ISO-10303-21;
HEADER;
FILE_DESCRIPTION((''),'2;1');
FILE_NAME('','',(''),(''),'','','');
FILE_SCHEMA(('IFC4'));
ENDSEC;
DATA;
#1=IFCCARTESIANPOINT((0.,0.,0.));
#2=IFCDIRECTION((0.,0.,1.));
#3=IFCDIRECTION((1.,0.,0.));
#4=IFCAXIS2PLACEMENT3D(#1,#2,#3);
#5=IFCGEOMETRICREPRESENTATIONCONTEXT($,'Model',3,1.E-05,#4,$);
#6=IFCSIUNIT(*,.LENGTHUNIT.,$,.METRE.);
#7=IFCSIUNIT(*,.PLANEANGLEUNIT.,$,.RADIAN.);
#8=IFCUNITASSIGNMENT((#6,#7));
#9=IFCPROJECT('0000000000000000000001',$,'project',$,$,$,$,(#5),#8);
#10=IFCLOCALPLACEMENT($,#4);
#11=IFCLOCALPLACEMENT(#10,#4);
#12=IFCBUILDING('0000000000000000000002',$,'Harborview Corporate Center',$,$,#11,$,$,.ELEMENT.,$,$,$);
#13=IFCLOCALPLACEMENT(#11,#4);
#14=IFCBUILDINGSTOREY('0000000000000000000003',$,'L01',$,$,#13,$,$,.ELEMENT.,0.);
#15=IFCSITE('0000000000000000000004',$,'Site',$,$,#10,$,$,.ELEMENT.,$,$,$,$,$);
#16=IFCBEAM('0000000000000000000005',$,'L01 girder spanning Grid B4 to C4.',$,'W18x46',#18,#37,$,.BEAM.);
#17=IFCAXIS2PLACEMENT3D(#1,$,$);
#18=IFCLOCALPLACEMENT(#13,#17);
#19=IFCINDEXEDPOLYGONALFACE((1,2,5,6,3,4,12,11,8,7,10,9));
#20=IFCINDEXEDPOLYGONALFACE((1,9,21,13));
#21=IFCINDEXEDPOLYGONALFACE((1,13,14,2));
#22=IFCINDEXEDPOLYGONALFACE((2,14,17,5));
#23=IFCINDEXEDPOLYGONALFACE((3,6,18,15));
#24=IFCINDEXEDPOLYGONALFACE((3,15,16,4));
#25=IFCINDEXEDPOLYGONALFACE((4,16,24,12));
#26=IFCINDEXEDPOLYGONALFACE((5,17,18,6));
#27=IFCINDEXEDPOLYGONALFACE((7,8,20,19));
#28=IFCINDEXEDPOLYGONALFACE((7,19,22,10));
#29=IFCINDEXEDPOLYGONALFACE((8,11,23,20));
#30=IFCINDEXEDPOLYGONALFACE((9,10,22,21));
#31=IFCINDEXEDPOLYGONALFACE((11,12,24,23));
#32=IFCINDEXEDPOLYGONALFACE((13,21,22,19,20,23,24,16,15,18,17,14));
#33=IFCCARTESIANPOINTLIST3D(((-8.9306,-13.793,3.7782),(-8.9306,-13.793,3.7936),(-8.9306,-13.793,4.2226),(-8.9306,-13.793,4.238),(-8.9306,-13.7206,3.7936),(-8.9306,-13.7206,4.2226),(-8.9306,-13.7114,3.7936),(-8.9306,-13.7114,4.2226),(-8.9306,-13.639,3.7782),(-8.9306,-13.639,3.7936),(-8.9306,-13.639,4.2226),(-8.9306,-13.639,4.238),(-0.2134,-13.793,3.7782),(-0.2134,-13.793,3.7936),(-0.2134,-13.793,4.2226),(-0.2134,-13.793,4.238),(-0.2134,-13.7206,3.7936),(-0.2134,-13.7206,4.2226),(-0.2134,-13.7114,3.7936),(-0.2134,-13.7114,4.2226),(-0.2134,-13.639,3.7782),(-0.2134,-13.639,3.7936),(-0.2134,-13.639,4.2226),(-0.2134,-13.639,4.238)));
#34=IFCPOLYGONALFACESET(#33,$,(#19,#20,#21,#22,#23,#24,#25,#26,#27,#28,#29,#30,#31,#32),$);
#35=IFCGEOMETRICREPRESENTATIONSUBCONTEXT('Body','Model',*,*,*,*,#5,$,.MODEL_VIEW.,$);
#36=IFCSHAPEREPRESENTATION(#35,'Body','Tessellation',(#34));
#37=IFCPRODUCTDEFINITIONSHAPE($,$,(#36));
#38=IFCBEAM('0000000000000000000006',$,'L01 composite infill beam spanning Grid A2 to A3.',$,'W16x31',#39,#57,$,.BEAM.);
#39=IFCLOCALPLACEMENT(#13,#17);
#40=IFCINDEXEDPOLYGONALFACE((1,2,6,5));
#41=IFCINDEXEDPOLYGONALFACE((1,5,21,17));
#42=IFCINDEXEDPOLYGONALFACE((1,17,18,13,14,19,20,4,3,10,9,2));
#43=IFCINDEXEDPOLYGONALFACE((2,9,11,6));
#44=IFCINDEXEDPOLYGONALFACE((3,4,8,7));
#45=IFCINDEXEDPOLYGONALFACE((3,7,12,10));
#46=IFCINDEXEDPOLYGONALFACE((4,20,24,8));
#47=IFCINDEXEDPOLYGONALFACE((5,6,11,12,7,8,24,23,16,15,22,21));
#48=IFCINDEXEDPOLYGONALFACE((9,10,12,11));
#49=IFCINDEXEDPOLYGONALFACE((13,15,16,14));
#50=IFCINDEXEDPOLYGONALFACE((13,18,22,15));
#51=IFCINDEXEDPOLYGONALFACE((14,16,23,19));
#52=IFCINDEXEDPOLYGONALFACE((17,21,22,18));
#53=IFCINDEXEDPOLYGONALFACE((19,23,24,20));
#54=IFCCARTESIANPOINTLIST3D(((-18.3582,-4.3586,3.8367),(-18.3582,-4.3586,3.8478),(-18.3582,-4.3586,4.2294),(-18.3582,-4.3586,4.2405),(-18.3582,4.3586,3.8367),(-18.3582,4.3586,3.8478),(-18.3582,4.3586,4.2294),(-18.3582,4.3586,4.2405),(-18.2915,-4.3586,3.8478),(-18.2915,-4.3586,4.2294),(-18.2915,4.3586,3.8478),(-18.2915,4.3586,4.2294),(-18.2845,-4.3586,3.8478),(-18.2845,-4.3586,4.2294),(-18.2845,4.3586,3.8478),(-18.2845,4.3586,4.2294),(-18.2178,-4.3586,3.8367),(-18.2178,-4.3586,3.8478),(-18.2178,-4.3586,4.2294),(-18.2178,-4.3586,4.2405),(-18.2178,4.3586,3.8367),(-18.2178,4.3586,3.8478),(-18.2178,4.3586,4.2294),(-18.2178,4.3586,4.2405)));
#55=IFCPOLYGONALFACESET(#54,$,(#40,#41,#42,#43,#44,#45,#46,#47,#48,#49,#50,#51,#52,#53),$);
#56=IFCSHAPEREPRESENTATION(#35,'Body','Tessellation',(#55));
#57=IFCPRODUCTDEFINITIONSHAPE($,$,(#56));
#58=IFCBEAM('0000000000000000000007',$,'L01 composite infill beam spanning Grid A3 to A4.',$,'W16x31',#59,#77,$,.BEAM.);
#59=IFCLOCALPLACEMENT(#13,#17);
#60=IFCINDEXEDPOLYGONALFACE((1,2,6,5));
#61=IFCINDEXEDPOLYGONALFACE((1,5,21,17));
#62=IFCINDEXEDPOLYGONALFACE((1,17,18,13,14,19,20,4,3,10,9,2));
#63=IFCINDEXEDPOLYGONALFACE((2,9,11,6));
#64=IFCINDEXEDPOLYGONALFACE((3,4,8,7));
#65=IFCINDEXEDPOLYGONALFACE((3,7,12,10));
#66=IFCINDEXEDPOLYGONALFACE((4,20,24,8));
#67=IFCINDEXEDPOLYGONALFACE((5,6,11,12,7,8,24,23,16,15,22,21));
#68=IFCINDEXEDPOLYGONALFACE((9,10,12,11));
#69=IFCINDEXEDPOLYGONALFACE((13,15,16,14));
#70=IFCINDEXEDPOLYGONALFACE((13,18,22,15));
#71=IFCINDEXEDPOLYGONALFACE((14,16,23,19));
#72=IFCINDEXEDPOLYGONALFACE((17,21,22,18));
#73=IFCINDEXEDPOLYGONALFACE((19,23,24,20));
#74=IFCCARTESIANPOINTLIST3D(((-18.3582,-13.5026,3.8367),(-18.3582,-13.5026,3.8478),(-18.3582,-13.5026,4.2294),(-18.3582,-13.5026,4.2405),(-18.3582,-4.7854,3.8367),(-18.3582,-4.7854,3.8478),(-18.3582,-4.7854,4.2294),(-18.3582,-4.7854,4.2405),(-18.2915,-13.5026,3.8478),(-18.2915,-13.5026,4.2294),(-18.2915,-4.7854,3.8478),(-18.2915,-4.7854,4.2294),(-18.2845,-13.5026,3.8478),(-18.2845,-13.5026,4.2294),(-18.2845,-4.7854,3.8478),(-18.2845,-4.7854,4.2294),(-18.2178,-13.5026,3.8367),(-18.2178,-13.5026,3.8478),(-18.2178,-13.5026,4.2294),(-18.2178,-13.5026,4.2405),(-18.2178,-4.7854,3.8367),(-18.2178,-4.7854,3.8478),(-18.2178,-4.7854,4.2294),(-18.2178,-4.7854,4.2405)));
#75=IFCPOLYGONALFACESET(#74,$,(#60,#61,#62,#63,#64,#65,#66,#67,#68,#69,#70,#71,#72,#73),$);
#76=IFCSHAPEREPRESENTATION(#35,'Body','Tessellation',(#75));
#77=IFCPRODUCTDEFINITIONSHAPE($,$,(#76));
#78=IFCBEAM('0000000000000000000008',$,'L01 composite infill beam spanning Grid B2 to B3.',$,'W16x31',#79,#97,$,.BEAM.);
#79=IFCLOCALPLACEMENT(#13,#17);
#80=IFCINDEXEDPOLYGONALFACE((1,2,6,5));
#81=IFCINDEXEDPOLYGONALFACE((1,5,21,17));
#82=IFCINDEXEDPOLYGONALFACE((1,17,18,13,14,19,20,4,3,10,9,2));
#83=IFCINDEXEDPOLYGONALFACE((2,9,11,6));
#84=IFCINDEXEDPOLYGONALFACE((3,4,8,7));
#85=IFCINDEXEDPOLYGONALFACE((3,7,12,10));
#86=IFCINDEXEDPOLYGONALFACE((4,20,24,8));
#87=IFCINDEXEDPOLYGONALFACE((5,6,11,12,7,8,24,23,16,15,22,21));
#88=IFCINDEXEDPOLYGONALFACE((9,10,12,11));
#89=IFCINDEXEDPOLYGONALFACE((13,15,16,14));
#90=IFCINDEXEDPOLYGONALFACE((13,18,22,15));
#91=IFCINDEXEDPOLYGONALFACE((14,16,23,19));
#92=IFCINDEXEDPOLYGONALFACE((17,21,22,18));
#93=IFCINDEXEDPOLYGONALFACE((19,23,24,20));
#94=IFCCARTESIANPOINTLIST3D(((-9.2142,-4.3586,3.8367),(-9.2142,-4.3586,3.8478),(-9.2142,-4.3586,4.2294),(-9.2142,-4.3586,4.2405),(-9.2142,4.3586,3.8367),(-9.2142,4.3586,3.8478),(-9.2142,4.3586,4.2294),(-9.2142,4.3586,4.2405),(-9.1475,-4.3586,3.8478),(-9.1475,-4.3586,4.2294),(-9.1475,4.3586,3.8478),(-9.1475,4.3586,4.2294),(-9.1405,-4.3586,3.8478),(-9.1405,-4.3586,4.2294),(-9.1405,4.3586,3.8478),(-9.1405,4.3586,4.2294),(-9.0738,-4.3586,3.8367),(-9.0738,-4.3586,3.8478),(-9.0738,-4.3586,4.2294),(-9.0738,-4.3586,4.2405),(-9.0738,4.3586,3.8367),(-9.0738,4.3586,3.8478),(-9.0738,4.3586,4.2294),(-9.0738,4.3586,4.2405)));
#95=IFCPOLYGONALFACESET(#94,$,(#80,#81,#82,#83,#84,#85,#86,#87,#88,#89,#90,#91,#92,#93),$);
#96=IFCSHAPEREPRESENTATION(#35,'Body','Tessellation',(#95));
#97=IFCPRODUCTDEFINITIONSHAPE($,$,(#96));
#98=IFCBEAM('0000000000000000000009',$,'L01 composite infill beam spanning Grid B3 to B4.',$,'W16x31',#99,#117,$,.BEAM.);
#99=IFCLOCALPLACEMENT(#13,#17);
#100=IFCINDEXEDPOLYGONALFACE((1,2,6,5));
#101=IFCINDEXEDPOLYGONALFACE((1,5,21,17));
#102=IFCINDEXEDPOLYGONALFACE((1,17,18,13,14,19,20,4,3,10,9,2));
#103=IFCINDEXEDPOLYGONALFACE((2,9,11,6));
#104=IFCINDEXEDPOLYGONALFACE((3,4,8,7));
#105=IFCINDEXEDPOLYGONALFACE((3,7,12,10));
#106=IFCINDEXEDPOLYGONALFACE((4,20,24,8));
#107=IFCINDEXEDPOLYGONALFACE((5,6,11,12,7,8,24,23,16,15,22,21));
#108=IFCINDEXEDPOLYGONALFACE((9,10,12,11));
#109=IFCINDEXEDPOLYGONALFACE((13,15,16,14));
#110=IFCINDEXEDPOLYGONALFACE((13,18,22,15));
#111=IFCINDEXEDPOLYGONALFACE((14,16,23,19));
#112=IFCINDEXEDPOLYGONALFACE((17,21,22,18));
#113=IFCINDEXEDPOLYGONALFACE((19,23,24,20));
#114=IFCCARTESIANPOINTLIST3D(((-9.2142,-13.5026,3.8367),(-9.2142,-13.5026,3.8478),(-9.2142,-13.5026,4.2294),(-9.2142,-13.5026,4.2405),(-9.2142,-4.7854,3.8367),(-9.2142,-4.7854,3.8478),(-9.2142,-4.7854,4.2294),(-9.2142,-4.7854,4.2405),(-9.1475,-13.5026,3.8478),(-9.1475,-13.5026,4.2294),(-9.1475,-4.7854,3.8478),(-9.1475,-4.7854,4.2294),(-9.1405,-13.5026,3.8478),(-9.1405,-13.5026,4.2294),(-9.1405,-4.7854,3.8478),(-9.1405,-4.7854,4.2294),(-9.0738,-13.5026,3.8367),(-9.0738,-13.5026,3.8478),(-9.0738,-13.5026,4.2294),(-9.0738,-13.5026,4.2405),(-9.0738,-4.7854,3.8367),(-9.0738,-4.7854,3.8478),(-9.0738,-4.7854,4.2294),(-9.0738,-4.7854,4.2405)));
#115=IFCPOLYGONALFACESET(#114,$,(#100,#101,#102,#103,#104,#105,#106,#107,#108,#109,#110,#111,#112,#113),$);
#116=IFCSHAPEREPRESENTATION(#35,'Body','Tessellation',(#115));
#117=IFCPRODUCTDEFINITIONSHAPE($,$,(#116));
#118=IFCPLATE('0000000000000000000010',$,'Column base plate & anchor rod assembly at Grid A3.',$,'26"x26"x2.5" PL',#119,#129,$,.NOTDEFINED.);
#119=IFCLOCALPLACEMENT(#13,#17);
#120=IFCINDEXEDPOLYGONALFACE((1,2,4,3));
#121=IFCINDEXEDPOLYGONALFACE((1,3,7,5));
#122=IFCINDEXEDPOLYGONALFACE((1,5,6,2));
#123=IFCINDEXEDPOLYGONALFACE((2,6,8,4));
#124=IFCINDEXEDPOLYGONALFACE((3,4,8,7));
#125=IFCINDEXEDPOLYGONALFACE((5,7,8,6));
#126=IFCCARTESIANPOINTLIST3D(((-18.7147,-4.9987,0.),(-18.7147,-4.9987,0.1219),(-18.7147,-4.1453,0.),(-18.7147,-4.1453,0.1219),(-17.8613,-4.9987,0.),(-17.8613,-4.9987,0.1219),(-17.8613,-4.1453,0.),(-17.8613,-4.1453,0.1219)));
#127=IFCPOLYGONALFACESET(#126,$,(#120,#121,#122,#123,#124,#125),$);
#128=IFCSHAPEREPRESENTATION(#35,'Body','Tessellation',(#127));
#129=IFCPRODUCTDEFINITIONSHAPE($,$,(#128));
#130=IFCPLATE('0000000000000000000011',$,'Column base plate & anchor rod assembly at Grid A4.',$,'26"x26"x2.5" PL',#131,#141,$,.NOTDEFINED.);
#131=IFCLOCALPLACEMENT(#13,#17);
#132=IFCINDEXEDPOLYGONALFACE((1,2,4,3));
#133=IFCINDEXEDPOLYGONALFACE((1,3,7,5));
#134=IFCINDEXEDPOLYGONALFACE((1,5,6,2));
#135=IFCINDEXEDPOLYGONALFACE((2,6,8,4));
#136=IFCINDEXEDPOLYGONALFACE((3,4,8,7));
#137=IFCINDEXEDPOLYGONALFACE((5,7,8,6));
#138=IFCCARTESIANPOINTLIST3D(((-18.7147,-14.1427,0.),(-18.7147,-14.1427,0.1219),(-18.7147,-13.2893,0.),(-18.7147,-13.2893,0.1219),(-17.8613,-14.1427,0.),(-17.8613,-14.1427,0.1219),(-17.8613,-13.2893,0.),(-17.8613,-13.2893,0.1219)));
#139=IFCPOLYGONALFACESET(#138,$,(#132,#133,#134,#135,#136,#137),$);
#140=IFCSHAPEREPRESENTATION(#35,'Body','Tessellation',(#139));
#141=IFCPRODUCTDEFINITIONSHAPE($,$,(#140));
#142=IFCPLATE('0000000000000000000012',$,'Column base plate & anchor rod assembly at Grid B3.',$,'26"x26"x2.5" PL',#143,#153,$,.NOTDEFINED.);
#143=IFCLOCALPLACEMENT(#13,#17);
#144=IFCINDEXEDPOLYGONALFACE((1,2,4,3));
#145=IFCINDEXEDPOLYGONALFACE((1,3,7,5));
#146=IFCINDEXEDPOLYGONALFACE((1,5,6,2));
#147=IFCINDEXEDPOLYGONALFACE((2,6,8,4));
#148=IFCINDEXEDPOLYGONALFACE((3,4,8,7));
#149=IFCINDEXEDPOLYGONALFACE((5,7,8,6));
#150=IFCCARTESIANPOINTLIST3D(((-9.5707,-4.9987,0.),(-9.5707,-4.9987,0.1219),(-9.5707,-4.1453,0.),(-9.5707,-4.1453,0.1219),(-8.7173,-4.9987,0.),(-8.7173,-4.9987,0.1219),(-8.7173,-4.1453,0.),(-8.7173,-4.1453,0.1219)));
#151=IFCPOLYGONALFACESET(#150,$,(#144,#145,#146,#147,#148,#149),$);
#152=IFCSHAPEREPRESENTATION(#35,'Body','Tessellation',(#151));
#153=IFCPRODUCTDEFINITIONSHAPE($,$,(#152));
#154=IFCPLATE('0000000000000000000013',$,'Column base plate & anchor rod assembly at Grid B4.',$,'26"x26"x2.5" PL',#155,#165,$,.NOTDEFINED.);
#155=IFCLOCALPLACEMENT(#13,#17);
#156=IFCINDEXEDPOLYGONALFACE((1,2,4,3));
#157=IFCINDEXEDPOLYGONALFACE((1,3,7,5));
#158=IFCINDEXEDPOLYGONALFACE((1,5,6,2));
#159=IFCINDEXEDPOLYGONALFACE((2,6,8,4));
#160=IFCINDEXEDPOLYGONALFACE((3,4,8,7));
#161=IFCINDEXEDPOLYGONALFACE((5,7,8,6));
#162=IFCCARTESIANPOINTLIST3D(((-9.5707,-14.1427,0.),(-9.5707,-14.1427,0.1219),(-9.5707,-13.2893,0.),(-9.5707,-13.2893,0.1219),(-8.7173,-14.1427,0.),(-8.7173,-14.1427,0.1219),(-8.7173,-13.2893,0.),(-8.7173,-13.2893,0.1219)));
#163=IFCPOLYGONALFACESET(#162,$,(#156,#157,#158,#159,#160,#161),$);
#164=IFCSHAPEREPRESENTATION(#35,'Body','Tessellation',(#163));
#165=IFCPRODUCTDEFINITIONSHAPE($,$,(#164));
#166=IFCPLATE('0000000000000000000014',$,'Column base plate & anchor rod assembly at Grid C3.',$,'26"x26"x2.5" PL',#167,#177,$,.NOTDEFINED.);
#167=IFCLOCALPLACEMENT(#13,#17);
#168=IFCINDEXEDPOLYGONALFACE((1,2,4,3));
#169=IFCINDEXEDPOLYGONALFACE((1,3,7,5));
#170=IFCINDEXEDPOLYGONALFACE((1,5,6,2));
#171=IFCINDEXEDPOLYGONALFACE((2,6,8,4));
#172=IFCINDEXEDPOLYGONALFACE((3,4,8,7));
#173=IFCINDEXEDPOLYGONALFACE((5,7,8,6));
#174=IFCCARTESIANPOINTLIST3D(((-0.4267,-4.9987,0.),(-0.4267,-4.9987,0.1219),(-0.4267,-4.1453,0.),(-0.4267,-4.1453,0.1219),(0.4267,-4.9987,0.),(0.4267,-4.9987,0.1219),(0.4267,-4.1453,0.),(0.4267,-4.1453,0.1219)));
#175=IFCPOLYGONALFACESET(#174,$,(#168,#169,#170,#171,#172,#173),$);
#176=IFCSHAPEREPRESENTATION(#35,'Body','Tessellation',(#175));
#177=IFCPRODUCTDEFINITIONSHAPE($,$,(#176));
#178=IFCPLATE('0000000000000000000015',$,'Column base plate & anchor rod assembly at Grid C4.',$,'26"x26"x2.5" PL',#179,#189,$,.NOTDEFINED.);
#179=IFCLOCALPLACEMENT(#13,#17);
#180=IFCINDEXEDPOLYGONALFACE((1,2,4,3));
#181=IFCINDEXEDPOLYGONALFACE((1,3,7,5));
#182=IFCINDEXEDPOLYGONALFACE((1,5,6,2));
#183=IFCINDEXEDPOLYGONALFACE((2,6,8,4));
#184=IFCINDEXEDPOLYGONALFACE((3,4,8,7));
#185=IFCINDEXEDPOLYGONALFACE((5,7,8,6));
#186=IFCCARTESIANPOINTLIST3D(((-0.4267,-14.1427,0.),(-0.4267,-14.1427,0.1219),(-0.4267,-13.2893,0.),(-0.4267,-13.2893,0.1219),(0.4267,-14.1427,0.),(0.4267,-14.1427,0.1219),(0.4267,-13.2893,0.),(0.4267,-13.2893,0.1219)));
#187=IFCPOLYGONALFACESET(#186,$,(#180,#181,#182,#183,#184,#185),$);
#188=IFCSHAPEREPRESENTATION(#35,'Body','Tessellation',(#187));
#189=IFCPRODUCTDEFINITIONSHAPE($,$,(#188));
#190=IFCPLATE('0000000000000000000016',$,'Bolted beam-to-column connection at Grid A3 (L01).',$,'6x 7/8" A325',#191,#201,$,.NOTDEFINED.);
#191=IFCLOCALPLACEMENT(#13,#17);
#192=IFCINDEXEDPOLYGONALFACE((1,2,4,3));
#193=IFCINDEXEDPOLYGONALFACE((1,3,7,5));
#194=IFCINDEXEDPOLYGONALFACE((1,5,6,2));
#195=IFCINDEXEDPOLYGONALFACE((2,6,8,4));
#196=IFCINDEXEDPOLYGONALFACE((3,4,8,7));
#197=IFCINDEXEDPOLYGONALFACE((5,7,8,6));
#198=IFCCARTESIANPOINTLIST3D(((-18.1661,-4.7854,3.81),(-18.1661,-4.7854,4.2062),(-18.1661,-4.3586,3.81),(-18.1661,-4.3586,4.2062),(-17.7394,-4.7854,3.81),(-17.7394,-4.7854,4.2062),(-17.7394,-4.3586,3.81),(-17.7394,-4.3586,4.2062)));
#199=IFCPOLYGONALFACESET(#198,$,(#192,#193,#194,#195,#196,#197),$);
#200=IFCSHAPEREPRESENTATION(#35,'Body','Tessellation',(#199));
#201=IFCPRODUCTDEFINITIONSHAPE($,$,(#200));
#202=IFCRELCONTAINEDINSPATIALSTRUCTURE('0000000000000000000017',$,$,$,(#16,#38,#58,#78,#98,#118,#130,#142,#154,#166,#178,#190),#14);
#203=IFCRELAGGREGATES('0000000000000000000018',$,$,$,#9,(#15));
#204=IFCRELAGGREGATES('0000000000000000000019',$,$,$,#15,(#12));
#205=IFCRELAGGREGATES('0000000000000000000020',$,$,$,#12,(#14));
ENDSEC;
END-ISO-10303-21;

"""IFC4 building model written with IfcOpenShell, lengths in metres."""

from ifc_helpers import new_model, si_unit, frame, origin_with_axes, place, context, subcontext, project, spatial, rectangle, i_section, extrude, element, save


model = new_model("IFC4")

# Units and contexts
model_context = context("Model", 3, precision=1e-05, world=origin_with_axes())
body_context = subcontext(model_context, "Body", "Model", "MODEL_VIEW")
ifc_project = project(units=[si_unit("LENGTHUNIT", "METRE"), si_unit("PLANEANGLEUNIT", "RADIAN")], contexts=[model_context])

# Site, building, storey
site_placement = place(None, origin_with_axes())
site = spatial("IfcSite", under=ifc_project, at=site_placement, Name="Site", CompositionType="ELEMENT")
building_placement = place(site_placement, origin_with_axes())
building = spatial("IfcBuilding", under=site, at=building_placement, Name="Harborview Corporate Center", CompositionType="ELEMENT")
storey_placement = place(building_placement, origin_with_axes())
storey = spatial("IfcBuildingStorey", under=building, at=storey_placement, Name="L01", CompositionType="ELEMENT", Elevation=0.0)

# Beams
beam_1_placement = place(storey_placement, frame((-8.9306, -13.716, 4.0081), z_axis=(1.0, 0.0, 0.0), x_axis=(0.0, 1.0, 0.0)))
element("IfcBeam", 1, at=beam_1_placement, inside=storey, Name="L01 girder spanning Grid B4 to C4.", ObjectType="W18x46", PredefinedType="BEAM", context=body_context, shape_type="SweptSolid", body=[
    extrude(i_section(OverallWidth=0.1539, OverallDepth=0.4597, WebThickness=0.0091, FlangeThickness=0.0154), origin_with_axes(), (0.0, 0.0, 1.0), 8.7173),
])
beam_2_placement = place(storey_placement, frame((-18.288, -4.3586, 4.0386), z_axis=(0.0, 1.0, 0.0), x_axis=(-1.0, 0.0, 0.0)))
element("IfcBeam", 2, at=beam_2_placement, inside=storey, Name="L01 composite infill beam spanning Grid A2 to A3.", ObjectType="W16x31", PredefinedType="BEAM", context=body_context, shape_type="SweptSolid", body=[
    extrude(i_section(OverallWidth=0.1405, OverallDepth=0.4039, WebThickness=0.007, FlangeThickness=0.0112), origin_with_axes(), (0.0, 0.0, 1.0), 8.7173),
])
beam_3_placement = place(storey_placement, frame((-18.288, -13.5026, 4.0386), z_axis=(0.0, 1.0, 0.0), x_axis=(-1.0, 0.0, 0.0)))
element("IfcBeam", 3, at=beam_3_placement, inside=storey, Name="L01 composite infill beam spanning Grid A3 to A4.", ObjectType="W16x31", PredefinedType="BEAM", context=body_context, shape_type="SweptSolid", body=[
    extrude(i_section(OverallWidth=0.1405, OverallDepth=0.4039, WebThickness=0.007, FlangeThickness=0.0112), origin_with_axes(), (0.0, 0.0, 1.0), 8.7173),
])
beam_4_placement = place(storey_placement, frame((-9.144, -4.3586, 4.0386), z_axis=(0.0, 1.0, 0.0), x_axis=(-1.0, 0.0, 0.0)))
element("IfcBeam", 4, at=beam_4_placement, inside=storey, Name="L01 composite infill beam spanning Grid B2 to B3.", ObjectType="W16x31", PredefinedType="BEAM", context=body_context, shape_type="SweptSolid", body=[
    extrude(i_section(OverallWidth=0.1405, OverallDepth=0.4039, WebThickness=0.007, FlangeThickness=0.0112), origin_with_axes(), (0.0, 0.0, 1.0), 8.7173),
])
beam_5_placement = place(storey_placement, frame((-9.144, -13.5026, 4.0386), z_axis=(0.0, 1.0, 0.0), x_axis=(-1.0, 0.0, 0.0)))
element("IfcBeam", 5, at=beam_5_placement, inside=storey, Name="L01 composite infill beam spanning Grid B3 to B4.", ObjectType="W16x31", PredefinedType="BEAM", context=body_context, shape_type="SweptSolid", body=[
    extrude(i_section(OverallWidth=0.1405, OverallDepth=0.4039, WebThickness=0.007, FlangeThickness=0.0112), origin_with_axes(), (0.0, 0.0, 1.0), 8.7173),
])

# Plates
plate_1_placement = place(storey_placement, frame((-18.288, -4.572, 0.0), z_axis=(0.0, 0.0, 1.0), x_axis=(1.0, 0.0, 0.0)))
element("IfcPlate", 6, at=plate_1_placement, inside=storey, Name="Column base plate & anchor rod assembly at Grid A3.", ObjectType="26\"x26\"x2.5\" PL", PredefinedType="NOTDEFINED", context=body_context, shape_type="SweptSolid", body=[
    extrude(rectangle(XDim=0.8534, YDim=0.8534), origin_with_axes(), (0.0, 0.0, 1.0), 0.1219),
])
plate_2_placement = place(storey_placement, frame((-18.288, -13.716, 0.0), z_axis=(0.0, 0.0, 1.0), x_axis=(1.0, 0.0, 0.0)))
element("IfcPlate", 7, at=plate_2_placement, inside=storey, Name="Column base plate & anchor rod assembly at Grid A4.", ObjectType="26\"x26\"x2.5\" PL", PredefinedType="NOTDEFINED", context=body_context, shape_type="SweptSolid", body=[
    extrude(rectangle(XDim=0.8534, YDim=0.8534), origin_with_axes(), (0.0, 0.0, 1.0), 0.1219),
])
plate_3_placement = place(storey_placement, frame((-9.144, -4.572, 0.0), z_axis=(0.0, 0.0, 1.0), x_axis=(1.0, 0.0, 0.0)))
element("IfcPlate", 8, at=plate_3_placement, inside=storey, Name="Column base plate & anchor rod assembly at Grid B3.", ObjectType="26\"x26\"x2.5\" PL", PredefinedType="NOTDEFINED", context=body_context, shape_type="SweptSolid", body=[
    extrude(rectangle(XDim=0.8534, YDim=0.8534), origin_with_axes(), (0.0, 0.0, 1.0), 0.1219),
])
plate_4_placement = place(storey_placement, frame((-9.144, -13.716, 0.0), z_axis=(0.0, 0.0, 1.0), x_axis=(1.0, 0.0, 0.0)))
element("IfcPlate", 9, at=plate_4_placement, inside=storey, Name="Column base plate & anchor rod assembly at Grid B4.", ObjectType="26\"x26\"x2.5\" PL", PredefinedType="NOTDEFINED", context=body_context, shape_type="SweptSolid", body=[
    extrude(rectangle(XDim=0.8534, YDim=0.8534), origin_with_axes(), (0.0, 0.0, 1.0), 0.1219),
])
plate_5_placement = place(storey_placement, frame((0.0, -4.572, 0.0), z_axis=(0.0, 0.0, 1.0), x_axis=(1.0, 0.0, 0.0)))
element("IfcPlate", 10, at=plate_5_placement, inside=storey, Name="Column base plate & anchor rod assembly at Grid C3.", ObjectType="26\"x26\"x2.5\" PL", PredefinedType="NOTDEFINED", context=body_context, shape_type="SweptSolid", body=[
    extrude(rectangle(XDim=0.8534, YDim=0.8534), origin_with_axes(), (0.0, 0.0, 1.0), 0.1219),
])
plate_6_placement = place(storey_placement, frame((0.0, -13.716, 0.0), z_axis=(0.0, 0.0, 1.0), x_axis=(1.0, 0.0, 0.0)))
element("IfcPlate", 11, at=plate_6_placement, inside=storey, Name="Column base plate & anchor rod assembly at Grid C4.", ObjectType="26\"x26\"x2.5\" PL", PredefinedType="NOTDEFINED", context=body_context, shape_type="SweptSolid", body=[
    extrude(rectangle(XDim=0.8534, YDim=0.8534), origin_with_axes(), (0.0, 0.0, 1.0), 0.1219),
])
plate_7_placement = place(storey_placement, frame((-17.9527, -4.572, 3.81), z_axis=(0.0, 0.0, 1.0), x_axis=(1.0, 0.0, 0.0)))
element("IfcPlate", 12, at=plate_7_placement, inside=storey, Name="Bolted beam-to-column connection at Grid A3 (L01).", ObjectType="6x 7/8\" A325", PredefinedType="NOTDEFINED", context=body_context, shape_type="SweptSolid", body=[
    extrude(rectangle(XDim=0.4267, YDim=0.4267), origin_with_axes(), (0.0, 0.0, 1.0), 0.3962),
])

save(model, "model.ifc")
